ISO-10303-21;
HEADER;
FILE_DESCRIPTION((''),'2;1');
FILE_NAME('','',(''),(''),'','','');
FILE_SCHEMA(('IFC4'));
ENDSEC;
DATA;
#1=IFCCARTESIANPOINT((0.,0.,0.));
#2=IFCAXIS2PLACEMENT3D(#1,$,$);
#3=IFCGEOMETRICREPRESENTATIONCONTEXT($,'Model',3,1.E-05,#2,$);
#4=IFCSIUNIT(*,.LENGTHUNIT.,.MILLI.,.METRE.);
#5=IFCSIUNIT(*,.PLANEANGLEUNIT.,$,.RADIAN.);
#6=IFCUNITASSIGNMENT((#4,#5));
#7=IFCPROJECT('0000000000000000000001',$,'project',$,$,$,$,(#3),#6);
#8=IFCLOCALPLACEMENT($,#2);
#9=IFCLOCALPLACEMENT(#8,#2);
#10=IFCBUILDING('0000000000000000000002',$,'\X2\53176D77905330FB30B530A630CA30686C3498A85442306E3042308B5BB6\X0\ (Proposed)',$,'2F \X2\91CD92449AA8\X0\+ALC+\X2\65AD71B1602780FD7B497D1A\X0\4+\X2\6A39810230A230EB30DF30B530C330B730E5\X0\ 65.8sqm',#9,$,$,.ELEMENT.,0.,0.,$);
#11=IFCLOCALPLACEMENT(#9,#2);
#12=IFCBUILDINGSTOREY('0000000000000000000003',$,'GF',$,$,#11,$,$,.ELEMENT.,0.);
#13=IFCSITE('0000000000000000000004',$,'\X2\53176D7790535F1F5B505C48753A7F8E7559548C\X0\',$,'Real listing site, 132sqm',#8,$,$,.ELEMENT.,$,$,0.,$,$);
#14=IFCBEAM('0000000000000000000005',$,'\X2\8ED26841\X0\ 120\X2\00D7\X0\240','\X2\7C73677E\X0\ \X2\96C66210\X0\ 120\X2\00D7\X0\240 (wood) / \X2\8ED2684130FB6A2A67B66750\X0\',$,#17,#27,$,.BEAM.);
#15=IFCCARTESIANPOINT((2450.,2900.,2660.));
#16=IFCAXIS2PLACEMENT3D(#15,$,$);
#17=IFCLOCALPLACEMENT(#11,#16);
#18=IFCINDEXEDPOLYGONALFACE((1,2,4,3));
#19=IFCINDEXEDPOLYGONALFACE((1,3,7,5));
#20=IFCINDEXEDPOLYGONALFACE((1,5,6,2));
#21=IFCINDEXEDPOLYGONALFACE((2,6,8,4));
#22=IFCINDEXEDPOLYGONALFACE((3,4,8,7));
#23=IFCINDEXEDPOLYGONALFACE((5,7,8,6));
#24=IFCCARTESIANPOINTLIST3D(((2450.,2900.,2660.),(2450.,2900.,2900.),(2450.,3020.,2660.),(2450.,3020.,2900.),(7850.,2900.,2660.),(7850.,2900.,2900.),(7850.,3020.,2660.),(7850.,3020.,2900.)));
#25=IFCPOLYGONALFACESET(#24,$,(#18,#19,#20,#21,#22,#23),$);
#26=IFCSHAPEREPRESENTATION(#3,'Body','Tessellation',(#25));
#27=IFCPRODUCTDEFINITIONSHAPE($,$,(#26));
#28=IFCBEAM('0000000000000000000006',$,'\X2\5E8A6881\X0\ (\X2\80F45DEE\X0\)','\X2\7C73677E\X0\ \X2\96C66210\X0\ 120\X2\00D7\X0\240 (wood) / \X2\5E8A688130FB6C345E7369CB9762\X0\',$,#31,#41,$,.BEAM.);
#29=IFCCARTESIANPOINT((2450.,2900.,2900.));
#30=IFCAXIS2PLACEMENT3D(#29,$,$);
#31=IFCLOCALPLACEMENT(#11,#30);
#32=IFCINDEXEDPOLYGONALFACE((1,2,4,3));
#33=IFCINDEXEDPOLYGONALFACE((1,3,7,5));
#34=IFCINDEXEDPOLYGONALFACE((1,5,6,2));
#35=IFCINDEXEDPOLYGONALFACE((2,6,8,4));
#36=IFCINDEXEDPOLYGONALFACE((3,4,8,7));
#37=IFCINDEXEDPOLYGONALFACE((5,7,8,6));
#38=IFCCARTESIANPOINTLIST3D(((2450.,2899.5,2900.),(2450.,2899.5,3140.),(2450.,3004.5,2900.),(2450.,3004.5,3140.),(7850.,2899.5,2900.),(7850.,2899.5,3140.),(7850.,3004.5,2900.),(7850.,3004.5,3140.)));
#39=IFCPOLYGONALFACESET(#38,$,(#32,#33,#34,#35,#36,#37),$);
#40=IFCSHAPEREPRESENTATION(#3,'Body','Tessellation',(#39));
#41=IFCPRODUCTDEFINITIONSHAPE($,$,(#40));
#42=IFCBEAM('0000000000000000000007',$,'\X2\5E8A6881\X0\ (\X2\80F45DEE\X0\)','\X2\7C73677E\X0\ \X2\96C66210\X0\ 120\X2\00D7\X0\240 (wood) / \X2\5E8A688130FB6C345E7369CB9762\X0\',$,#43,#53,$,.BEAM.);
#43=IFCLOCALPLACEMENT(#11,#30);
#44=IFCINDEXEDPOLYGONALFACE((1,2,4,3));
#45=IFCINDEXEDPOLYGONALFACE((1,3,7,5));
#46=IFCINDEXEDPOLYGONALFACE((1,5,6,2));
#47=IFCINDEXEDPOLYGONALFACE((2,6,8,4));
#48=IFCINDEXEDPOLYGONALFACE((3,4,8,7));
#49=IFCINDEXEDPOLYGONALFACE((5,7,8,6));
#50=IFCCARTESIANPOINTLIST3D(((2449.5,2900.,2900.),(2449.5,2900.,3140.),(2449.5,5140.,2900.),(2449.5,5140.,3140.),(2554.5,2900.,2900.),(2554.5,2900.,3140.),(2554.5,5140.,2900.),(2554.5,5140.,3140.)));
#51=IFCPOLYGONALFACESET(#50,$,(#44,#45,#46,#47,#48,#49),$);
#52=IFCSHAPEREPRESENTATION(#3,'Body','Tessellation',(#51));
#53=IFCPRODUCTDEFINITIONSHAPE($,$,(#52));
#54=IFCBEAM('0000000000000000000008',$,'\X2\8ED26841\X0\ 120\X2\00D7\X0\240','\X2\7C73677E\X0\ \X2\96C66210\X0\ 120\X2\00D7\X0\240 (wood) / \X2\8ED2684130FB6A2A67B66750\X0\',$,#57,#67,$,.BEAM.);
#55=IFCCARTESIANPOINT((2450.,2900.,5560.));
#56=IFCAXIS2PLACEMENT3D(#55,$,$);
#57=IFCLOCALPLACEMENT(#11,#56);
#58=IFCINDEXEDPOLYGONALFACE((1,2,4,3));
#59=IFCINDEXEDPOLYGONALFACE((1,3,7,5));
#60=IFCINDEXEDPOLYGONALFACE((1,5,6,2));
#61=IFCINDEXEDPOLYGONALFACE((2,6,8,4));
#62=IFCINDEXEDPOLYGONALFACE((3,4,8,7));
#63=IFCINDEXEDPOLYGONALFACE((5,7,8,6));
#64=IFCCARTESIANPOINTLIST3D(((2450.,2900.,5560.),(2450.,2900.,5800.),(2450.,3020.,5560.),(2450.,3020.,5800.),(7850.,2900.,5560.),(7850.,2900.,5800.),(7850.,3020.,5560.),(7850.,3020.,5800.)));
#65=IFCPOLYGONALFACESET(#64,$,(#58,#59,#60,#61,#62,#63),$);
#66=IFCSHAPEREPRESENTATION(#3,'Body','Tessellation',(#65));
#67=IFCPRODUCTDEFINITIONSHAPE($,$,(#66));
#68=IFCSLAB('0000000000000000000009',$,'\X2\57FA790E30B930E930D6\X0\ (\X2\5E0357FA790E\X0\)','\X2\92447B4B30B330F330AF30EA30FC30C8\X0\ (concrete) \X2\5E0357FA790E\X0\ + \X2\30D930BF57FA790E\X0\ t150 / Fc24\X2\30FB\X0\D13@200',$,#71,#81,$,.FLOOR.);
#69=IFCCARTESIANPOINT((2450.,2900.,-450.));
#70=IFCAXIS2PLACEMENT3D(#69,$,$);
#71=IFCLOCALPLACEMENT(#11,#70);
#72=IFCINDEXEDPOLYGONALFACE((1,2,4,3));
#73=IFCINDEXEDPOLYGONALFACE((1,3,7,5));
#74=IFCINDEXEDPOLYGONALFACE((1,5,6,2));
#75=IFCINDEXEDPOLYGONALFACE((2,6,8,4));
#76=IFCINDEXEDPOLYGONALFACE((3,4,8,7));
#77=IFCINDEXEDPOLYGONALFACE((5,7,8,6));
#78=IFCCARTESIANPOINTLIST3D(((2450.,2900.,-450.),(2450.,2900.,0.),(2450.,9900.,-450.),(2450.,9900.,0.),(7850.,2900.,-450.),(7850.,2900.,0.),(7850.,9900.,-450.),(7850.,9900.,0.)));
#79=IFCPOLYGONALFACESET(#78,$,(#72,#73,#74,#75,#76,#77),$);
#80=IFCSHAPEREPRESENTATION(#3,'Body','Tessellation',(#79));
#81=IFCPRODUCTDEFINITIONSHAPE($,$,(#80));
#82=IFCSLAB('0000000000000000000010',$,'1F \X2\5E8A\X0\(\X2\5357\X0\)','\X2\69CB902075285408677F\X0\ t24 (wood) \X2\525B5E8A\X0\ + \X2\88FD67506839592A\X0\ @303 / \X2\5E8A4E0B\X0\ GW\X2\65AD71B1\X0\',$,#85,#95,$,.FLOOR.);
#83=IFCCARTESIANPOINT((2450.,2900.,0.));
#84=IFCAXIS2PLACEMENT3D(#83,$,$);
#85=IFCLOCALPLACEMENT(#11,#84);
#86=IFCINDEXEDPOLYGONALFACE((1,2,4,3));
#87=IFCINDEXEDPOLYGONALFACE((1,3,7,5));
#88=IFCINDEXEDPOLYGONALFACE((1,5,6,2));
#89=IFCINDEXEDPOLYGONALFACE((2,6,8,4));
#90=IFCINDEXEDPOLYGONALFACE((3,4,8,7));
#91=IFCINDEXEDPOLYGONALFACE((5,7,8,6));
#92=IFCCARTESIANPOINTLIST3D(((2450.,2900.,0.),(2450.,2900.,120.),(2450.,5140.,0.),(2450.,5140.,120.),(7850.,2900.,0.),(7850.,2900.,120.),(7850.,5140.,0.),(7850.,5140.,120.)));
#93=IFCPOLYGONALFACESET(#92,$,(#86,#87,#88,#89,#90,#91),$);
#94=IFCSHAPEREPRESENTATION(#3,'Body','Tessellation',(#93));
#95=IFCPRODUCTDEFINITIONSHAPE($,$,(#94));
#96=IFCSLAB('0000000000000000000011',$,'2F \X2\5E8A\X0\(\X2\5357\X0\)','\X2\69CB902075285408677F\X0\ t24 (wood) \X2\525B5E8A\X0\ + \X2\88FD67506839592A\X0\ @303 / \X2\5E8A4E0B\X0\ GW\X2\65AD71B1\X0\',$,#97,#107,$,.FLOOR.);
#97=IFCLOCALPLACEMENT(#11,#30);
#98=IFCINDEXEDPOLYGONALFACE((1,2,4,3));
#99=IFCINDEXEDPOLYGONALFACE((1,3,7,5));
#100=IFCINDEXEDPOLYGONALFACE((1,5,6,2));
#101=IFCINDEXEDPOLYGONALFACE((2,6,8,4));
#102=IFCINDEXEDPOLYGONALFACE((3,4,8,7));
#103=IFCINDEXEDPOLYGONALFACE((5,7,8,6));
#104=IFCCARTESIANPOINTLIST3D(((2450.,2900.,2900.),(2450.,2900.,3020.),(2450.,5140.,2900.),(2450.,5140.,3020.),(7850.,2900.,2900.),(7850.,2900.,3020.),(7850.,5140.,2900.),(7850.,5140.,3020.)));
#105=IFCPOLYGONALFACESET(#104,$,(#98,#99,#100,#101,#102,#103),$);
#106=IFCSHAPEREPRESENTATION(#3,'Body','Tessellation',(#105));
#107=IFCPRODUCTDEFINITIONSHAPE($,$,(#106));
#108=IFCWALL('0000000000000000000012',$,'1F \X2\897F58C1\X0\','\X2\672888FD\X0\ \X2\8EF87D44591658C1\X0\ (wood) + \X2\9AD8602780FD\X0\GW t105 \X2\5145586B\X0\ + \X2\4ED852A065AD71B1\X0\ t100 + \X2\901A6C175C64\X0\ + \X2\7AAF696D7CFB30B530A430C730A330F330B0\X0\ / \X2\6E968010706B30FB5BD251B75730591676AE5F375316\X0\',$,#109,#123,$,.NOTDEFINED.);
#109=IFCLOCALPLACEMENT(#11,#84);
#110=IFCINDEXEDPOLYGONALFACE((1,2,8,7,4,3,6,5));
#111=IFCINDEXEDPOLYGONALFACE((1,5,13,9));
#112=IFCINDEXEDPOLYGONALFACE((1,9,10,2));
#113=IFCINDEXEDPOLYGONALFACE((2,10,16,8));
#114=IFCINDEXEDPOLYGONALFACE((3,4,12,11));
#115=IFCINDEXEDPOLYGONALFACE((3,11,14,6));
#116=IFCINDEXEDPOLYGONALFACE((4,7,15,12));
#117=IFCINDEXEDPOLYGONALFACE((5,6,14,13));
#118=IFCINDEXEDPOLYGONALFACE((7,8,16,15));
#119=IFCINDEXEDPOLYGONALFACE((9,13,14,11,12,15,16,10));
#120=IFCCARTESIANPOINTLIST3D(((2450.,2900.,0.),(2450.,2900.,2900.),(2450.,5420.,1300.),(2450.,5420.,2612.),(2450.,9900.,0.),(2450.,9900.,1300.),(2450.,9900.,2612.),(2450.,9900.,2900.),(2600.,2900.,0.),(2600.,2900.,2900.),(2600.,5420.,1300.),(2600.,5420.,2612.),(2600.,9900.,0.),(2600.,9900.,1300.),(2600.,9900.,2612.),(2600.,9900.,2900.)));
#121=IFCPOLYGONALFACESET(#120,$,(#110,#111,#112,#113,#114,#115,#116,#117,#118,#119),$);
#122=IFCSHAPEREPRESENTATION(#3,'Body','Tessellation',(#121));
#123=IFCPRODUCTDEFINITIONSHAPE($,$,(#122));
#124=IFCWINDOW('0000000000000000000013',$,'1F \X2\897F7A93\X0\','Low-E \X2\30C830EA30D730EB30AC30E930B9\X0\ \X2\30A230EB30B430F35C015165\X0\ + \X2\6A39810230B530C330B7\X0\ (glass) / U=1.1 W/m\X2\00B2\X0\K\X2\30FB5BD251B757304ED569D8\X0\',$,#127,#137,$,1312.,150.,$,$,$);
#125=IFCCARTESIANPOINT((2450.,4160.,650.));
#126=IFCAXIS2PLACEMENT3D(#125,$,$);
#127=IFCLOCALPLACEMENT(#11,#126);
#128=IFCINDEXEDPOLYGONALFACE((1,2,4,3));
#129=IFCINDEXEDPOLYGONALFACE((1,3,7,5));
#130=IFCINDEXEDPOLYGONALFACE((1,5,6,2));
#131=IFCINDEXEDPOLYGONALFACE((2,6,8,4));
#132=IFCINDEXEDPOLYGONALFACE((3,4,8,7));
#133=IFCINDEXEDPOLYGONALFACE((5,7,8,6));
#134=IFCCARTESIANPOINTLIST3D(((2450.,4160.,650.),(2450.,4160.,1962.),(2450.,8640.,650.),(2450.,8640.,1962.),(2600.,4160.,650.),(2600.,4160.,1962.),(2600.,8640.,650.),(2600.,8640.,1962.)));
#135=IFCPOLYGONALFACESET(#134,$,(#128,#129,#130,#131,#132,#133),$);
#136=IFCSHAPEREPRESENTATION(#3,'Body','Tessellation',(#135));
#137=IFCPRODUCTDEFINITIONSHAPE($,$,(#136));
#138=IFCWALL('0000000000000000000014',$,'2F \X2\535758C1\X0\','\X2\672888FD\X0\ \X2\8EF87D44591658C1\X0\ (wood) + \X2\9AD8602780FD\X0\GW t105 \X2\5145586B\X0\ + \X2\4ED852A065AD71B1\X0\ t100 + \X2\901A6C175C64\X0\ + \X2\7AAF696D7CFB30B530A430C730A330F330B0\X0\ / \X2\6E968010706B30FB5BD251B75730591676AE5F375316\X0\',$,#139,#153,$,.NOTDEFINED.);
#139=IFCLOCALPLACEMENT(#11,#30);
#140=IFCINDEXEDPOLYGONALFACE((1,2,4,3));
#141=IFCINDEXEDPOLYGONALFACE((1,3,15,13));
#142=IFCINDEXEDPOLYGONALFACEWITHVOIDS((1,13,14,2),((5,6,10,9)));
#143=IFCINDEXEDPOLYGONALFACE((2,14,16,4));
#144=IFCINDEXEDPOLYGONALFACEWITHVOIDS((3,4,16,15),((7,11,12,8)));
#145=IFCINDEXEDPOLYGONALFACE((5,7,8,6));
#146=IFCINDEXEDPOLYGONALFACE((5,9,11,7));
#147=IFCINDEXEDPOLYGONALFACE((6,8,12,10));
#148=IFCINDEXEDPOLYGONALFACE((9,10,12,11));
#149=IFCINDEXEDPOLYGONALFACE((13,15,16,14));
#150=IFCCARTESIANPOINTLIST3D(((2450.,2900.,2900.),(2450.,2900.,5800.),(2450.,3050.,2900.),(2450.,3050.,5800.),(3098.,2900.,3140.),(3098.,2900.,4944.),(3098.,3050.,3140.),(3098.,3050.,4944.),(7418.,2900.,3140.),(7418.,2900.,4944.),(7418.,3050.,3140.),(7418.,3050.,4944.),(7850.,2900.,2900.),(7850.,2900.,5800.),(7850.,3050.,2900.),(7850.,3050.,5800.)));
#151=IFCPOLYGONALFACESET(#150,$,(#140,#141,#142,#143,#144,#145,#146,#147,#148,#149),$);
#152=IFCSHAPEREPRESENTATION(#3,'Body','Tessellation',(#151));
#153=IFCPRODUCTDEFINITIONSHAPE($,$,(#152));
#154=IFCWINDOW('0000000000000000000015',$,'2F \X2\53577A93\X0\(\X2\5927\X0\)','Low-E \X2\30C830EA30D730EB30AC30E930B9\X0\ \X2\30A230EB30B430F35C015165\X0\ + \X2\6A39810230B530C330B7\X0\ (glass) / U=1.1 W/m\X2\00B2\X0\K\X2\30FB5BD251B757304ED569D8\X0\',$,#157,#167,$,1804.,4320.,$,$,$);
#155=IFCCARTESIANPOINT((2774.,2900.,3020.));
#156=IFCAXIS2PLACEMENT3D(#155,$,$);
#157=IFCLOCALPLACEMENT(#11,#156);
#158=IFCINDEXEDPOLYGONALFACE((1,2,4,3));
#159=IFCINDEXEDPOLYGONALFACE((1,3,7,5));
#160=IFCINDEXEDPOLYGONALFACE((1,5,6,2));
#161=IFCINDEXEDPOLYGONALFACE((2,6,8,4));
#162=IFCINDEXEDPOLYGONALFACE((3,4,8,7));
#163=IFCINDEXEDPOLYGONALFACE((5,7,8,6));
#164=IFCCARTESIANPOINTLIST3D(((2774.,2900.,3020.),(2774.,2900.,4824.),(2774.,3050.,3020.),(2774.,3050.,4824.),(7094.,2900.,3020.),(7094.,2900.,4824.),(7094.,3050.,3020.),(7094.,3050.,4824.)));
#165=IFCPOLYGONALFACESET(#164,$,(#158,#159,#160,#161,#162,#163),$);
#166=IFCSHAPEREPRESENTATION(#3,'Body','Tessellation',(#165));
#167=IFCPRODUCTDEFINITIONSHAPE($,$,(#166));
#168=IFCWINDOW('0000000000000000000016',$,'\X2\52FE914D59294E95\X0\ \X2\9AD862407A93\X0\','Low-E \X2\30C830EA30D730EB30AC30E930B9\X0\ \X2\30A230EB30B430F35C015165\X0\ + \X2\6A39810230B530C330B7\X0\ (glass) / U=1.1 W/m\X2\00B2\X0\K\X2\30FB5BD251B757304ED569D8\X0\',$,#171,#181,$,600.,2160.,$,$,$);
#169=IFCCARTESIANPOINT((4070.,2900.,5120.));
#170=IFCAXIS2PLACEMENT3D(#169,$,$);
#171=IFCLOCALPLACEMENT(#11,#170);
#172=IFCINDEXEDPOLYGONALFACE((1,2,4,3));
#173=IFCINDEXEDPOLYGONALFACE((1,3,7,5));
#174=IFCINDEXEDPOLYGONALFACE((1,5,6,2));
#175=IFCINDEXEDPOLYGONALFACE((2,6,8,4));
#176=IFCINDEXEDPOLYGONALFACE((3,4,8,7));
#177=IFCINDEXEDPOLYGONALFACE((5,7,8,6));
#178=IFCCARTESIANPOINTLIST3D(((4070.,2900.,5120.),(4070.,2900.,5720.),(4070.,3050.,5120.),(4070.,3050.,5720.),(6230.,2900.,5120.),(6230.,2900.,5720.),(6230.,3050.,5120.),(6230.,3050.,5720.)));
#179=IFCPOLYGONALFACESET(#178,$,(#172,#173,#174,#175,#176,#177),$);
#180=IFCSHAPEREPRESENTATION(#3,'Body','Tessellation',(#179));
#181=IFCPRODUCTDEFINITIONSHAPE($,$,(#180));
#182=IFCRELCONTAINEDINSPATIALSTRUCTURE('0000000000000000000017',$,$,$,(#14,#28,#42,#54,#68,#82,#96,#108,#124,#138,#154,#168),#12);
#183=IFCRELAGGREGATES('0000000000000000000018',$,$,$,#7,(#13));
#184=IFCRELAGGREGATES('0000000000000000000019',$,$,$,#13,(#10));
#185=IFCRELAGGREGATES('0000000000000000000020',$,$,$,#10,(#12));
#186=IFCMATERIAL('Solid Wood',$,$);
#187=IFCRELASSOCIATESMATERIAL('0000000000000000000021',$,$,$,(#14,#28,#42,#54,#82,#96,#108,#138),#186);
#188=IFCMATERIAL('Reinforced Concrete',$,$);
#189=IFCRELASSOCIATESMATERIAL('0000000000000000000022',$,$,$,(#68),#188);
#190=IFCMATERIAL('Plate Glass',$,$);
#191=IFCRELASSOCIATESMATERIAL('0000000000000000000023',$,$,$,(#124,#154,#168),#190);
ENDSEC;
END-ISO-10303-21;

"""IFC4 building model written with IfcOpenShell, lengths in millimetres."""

from ifc_helpers import new_model, si_unit, frame, frame_2d, origin, place, context, project, spatial, rectangle, extrude, material, element, fill, save


model = new_model("IFC4")

# Units and contexts
model_context = context("Model", 3, precision=1e-05, world=origin())
ifc_project = project(units=[si_unit("LENGTHUNIT", "METRE", prefix="MILLI"), si_unit("PLANEANGLEUNIT", "RADIAN")], contexts=[model_context])

# Site, building, storey
site_placement = place(None, origin())
site = spatial("IfcSite", under=ifc_project, at=site_placement, Name="北海道弟子屈町美留和", ObjectType="Real listing site, 132sqm", CompositionType="ELEMENT", RefElevation=0.0)
building_placement = place(site_placement, origin())
building = spatial("IfcBuilding", under=site, at=building_placement, Name="北海道・サウナと水風呂のある家 (Proposed)", ObjectType="2F 重鉄骨+ALC+断熱性能等級4+樹脂アルミサッシュ 65.8sqm", CompositionType="ELEMENT", ElevationOfRefHeight=0.0, ElevationOfTerrain=0.0)
storey_placement = place(building_placement, origin())
storey = spatial("IfcBuildingStorey", under=building, at=storey_placement, Name="GF", CompositionType="ELEMENT", Elevation=0.0)

# Shared definitions
ifc_material_1 = material(Name="Solid Wood")

# Beams
beam_1_placement = place(storey_placement, frame((2450.0, 2900.0, 2660.0)))
element("IfcBeam", 1, at=beam_1_placement, inside=storey, material=ifc_material_1, Name="軒桁 120×240", Description="米松 集成 120×240 (wood) / 軒桁・横架材", PredefinedType="BEAM", context=model_context, shape_type="SweptSolid", body=[
    extrude(rectangle(XDim=5400.0, YDim=120.0, at=frame_2d((2700.0, 60.0))), frame((2450.0, 2900.0, 2660.0)), (0.0, 0.0, 1.0), 240.0),
])
beam_2_placement = place(storey_placement, frame((2450.0, 2900.0, 2900.0)))
element("IfcBeam", 2, at=beam_2_placement, inside=storey, material=ifc_material_1, Name="床梁 (胴差)", Description="米松 集成 120×240 (wood) / 床梁・水平構面", PredefinedType="BEAM", context=model_context, shape_type="SweptSolid", body=[
    extrude(rectangle(XDim=5400.0, YDim=105.0, at=frame_2d((2700.0, 52.0))), frame((2450.0, 2900.0, 2900.0)), (0.0, 0.0, 1.0), 240.0),
])
beam_3_placement = place(storey_placement, frame((2450.0, 2900.0, 2900.0)))
element("IfcBeam", 3, at=beam_3_placement, inside=storey, material=ifc_material_1, Name="床梁 (胴差)", Description="米松 集成 120×240 (wood) / 床梁・水平構面", PredefinedType="BEAM", context=model_context, shape_type="SweptSolid", body=[
    extrude(rectangle(XDim=105.0, YDim=2240.0, at=frame_2d((52.0, 1120.0))), frame((2450.0, 2900.0, 2900.0)), (0.0, 0.0, 1.0), 240.0),
])
beam_4_placement = place(storey_placement, frame((2450.0, 2900.0, 5560.0)))
element("IfcBeam", 4, at=beam_4_placement, inside=storey, material=ifc_material_1, Name="軒桁 120×240", Description="米松 集成 120×240 (wood) / 軒桁・横架材", PredefinedType="BEAM", context=model_context, shape_type="SweptSolid", body=[
    extrude(rectangle(XDim=5400.0, YDim=120.0, at=frame_2d((2700.0, 60.0))), frame((2450.0, 2900.0, 5560.0)), (0.0, 0.0, 1.0), 240.0),
])

# Slabs
ifc_material_2 = material(Name="Reinforced Concrete")
slab_1_placement = place(storey_placement, frame((2450.0, 2900.0, -450.0)))
element("IfcSlab", 5, at=slab_1_placement, inside=storey, material=ifc_material_2, Name="基礎スラブ (布基礎)", Description="鉄筋コンクリート (concrete) 布基礎 + ベタ基礎 t150 / Fc24・D13@200", PredefinedType="FLOOR", context=model_context, shape_type="SweptSolid", body=[
    extrude(rectangle(XDim=5400.0, YDim=7000.0, at=frame_2d((2700.0, 3500.0))), frame((2450.0, 2900.0, -450.0)), (0.0, 0.0, 1.0), 450.0),
])
slab_2_placement = place(storey_placement, frame((2450.0, 2900.0, 0.0)))
element("IfcSlab", 6, at=slab_2_placement, inside=storey, material=ifc_material_1, Name="1F 床(南)", Description="構造用合板 t24 (wood) 剛床 + 製材根太 @303 / 床下 GW断熱", PredefinedType="FLOOR", context=model_context, shape_type="SweptSolid", body=[
    extrude(rectangle(XDim=5400.0, YDim=2240.0, at=frame_2d((2700.0, 1120.0))), frame((2450.0, 2900.0, 0.0)), (0.0, 0.0, 1.0), 120.0),
])
slab_3_placement = place(storey_placement, frame((2450.0, 2900.0, 2900.0)))
element("IfcSlab", 7, at=slab_3_placement, inside=storey, material=ifc_material_1, Name="2F 床(南)", Description="構造用合板 t24 (wood) 剛床 + 製材根太 @303 / 床下 GW断熱", PredefinedType="FLOOR", context=model_context, shape_type="SweptSolid", body=[
    extrude(rectangle(XDim=5400.0, YDim=2240.0, at=frame_2d((2700.0, 1120.0))), frame((2450.0, 2900.0, 2900.0)), (0.0, 0.0, 1.0), 120.0),
])

# Shared definitions
ifc_material_3 = material(Name="Plate Glass")

# Wall, opening, window
wall_1_placement = place(storey_placement, frame((2450.0, 2900.0, 0.0)))
wall_1 = element("IfcWall", 8, at=wall_1_placement, inside=storey, material=ifc_material_1, Name="1F 西壁", Description="木製 軸組外壁 (wood) + 高性能GW t105 充填 + 付加断熱 t100 + 通気層 + 窯業系サイディング / 準耐火・寒冷地外皮強化", PredefinedType="NOTDEFINED", context=model_context, shape_type="SweptSolid", body=[
    extrude(rectangle(XDim=150.0, YDim=7000.0, at=frame_2d((75.0, 3500.0))), frame((2450.0, 2900.0, 0.0)), (0.0, 0.0, 1.0), 2900.0),
])
opening_1_placement = place(storey_placement, frame((2450.0, 4160.0, 650.0)))
opening_1 = element("IfcOpeningElement", 9, at=opening_1_placement, cuts=wall_1, PredefinedType="NOTDEFINED", context=model_context, shape_type="SweptSolid", body=[
    extrude(rectangle(XDim=150.0, YDim=4480.0, at=frame_2d((75.0, 2240.0))), frame((2450.0, 4160.0, 650.0)), (0.0, 0.0, 1.0), 1312.0),
])
window_1_placement = place(storey_placement, frame((2450.0, 4160.0, 650.0)))
window_1 = element("IfcWindow", 10, at=window_1_placement, inside=storey, material=ifc_material_3, Name="1F 西窓", Description="Low-E トリプルガラス アルゴン封入 + 樹脂サッシ (glass) / U=1.1 W/m²K・寒冷地仕様", OverallHeight=1312.0, OverallWidth=150.0, context=model_context, shape_type="SweptSolid", body=[
    extrude(rectangle(XDim=150.0, YDim=4480.0, at=frame_2d((75.0, 2240.0))), frame((2450.0, 4160.0, 650.0)), (0.0, 0.0, 1.0), 1312.0),
])
fill(opening_1, window_1)

# Wall, openings, windows
wall_2_placement = place(storey_placement, frame((2450.0, 2900.0, 2900.0)))
wall_2 = element("IfcWall", 11, at=wall_2_placement, inside=storey, material=ifc_material_1, Name="2F 南壁", Description="木製 軸組外壁 (wood) + 高性能GW t105 充填 + 付加断熱 t100 + 通気層 + 窯業系サイディング / 準耐火・寒冷地外皮強化", PredefinedType="NOTDEFINED", context=model_context, shape_type="SweptSolid", body=[
    extrude(rectangle(XDim=5400.0, YDim=150.0, at=frame_2d((2700.0, 75.0))), frame((2450.0, 2900.0, 2900.0)), (0.0, 0.0, 1.0), 2900.0),
])
opening_2_placement = place(storey_placement, frame((2774.0, 2900.0, 3020.0)))
opening_2 = element("IfcOpeningElement", 12, at=opening_2_placement, cuts=wall_2, PredefinedType="NOTDEFINED", context=model_context, shape_type="SweptSolid", body=[
    extrude(rectangle(XDim=4320.0, YDim=150.0, at=frame_2d((2160.0, 75.0))), frame((2774.0, 2900.0, 3020.0)), (0.0, 0.0, 1.0), 1804.0),
])
opening_3_placement = place(storey_placement, frame((4070.0, 2900.0, 5120.0)))
opening_3 = element("IfcOpeningElement", 13, at=opening_3_placement, cuts=wall_2, PredefinedType="NOTDEFINED", context=model_context, shape_type="SweptSolid", body=[
    extrude(rectangle(XDim=2160.0, YDim=150.0, at=frame_2d((1080.0, 75.0))), frame((4070.0, 2900.0, 5120.0)), (0.0, 0.0, 1.0), 600.0),
])
window_2_placement = place(storey_placement, frame((2774.0, 2900.0, 3020.0)))
window_2 = element("IfcWindow", 14, at=window_2_placement, inside=storey, material=ifc_material_3, Name="2F 南窓(大)", Description="Low-E トリプルガラス アルゴン封入 + 樹脂サッシ (glass) / U=1.1 W/m²K・寒冷地仕様", OverallHeight=1804.0, OverallWidth=4320.0, context=model_context, shape_type="SweptSolid", body=[
    extrude(rectangle(XDim=4320.0, YDim=150.0, at=frame_2d((2160.0, 75.0))), frame((2774.0, 2900.0, 3020.0)), (0.0, 0.0, 1.0), 1804.0),
])
fill(opening_2, window_2)
window_3_placement = place(storey_placement, frame((4070.0, 2900.0, 5120.0)))
window_3 = element("IfcWindow", 15, at=window_3_placement, inside=storey, material=ifc_material_3, Name="勾配天井 高所窓", Description="Low-E トリプルガラス アルゴン封入 + 樹脂サッシ (glass) / U=1.1 W/m²K・寒冷地仕様", OverallHeight=600.0, OverallWidth=2160.0, context=model_context, shape_type="SweptSolid", body=[
    extrude(rectangle(XDim=2160.0, YDim=150.0, at=frame_2d((1080.0, 75.0))), frame((4070.0, 2900.0, 5120.0)), (0.0, 0.0, 1.0), 600.0),
])
fill(opening_3, window_3)

save(model, "model.ifc")
